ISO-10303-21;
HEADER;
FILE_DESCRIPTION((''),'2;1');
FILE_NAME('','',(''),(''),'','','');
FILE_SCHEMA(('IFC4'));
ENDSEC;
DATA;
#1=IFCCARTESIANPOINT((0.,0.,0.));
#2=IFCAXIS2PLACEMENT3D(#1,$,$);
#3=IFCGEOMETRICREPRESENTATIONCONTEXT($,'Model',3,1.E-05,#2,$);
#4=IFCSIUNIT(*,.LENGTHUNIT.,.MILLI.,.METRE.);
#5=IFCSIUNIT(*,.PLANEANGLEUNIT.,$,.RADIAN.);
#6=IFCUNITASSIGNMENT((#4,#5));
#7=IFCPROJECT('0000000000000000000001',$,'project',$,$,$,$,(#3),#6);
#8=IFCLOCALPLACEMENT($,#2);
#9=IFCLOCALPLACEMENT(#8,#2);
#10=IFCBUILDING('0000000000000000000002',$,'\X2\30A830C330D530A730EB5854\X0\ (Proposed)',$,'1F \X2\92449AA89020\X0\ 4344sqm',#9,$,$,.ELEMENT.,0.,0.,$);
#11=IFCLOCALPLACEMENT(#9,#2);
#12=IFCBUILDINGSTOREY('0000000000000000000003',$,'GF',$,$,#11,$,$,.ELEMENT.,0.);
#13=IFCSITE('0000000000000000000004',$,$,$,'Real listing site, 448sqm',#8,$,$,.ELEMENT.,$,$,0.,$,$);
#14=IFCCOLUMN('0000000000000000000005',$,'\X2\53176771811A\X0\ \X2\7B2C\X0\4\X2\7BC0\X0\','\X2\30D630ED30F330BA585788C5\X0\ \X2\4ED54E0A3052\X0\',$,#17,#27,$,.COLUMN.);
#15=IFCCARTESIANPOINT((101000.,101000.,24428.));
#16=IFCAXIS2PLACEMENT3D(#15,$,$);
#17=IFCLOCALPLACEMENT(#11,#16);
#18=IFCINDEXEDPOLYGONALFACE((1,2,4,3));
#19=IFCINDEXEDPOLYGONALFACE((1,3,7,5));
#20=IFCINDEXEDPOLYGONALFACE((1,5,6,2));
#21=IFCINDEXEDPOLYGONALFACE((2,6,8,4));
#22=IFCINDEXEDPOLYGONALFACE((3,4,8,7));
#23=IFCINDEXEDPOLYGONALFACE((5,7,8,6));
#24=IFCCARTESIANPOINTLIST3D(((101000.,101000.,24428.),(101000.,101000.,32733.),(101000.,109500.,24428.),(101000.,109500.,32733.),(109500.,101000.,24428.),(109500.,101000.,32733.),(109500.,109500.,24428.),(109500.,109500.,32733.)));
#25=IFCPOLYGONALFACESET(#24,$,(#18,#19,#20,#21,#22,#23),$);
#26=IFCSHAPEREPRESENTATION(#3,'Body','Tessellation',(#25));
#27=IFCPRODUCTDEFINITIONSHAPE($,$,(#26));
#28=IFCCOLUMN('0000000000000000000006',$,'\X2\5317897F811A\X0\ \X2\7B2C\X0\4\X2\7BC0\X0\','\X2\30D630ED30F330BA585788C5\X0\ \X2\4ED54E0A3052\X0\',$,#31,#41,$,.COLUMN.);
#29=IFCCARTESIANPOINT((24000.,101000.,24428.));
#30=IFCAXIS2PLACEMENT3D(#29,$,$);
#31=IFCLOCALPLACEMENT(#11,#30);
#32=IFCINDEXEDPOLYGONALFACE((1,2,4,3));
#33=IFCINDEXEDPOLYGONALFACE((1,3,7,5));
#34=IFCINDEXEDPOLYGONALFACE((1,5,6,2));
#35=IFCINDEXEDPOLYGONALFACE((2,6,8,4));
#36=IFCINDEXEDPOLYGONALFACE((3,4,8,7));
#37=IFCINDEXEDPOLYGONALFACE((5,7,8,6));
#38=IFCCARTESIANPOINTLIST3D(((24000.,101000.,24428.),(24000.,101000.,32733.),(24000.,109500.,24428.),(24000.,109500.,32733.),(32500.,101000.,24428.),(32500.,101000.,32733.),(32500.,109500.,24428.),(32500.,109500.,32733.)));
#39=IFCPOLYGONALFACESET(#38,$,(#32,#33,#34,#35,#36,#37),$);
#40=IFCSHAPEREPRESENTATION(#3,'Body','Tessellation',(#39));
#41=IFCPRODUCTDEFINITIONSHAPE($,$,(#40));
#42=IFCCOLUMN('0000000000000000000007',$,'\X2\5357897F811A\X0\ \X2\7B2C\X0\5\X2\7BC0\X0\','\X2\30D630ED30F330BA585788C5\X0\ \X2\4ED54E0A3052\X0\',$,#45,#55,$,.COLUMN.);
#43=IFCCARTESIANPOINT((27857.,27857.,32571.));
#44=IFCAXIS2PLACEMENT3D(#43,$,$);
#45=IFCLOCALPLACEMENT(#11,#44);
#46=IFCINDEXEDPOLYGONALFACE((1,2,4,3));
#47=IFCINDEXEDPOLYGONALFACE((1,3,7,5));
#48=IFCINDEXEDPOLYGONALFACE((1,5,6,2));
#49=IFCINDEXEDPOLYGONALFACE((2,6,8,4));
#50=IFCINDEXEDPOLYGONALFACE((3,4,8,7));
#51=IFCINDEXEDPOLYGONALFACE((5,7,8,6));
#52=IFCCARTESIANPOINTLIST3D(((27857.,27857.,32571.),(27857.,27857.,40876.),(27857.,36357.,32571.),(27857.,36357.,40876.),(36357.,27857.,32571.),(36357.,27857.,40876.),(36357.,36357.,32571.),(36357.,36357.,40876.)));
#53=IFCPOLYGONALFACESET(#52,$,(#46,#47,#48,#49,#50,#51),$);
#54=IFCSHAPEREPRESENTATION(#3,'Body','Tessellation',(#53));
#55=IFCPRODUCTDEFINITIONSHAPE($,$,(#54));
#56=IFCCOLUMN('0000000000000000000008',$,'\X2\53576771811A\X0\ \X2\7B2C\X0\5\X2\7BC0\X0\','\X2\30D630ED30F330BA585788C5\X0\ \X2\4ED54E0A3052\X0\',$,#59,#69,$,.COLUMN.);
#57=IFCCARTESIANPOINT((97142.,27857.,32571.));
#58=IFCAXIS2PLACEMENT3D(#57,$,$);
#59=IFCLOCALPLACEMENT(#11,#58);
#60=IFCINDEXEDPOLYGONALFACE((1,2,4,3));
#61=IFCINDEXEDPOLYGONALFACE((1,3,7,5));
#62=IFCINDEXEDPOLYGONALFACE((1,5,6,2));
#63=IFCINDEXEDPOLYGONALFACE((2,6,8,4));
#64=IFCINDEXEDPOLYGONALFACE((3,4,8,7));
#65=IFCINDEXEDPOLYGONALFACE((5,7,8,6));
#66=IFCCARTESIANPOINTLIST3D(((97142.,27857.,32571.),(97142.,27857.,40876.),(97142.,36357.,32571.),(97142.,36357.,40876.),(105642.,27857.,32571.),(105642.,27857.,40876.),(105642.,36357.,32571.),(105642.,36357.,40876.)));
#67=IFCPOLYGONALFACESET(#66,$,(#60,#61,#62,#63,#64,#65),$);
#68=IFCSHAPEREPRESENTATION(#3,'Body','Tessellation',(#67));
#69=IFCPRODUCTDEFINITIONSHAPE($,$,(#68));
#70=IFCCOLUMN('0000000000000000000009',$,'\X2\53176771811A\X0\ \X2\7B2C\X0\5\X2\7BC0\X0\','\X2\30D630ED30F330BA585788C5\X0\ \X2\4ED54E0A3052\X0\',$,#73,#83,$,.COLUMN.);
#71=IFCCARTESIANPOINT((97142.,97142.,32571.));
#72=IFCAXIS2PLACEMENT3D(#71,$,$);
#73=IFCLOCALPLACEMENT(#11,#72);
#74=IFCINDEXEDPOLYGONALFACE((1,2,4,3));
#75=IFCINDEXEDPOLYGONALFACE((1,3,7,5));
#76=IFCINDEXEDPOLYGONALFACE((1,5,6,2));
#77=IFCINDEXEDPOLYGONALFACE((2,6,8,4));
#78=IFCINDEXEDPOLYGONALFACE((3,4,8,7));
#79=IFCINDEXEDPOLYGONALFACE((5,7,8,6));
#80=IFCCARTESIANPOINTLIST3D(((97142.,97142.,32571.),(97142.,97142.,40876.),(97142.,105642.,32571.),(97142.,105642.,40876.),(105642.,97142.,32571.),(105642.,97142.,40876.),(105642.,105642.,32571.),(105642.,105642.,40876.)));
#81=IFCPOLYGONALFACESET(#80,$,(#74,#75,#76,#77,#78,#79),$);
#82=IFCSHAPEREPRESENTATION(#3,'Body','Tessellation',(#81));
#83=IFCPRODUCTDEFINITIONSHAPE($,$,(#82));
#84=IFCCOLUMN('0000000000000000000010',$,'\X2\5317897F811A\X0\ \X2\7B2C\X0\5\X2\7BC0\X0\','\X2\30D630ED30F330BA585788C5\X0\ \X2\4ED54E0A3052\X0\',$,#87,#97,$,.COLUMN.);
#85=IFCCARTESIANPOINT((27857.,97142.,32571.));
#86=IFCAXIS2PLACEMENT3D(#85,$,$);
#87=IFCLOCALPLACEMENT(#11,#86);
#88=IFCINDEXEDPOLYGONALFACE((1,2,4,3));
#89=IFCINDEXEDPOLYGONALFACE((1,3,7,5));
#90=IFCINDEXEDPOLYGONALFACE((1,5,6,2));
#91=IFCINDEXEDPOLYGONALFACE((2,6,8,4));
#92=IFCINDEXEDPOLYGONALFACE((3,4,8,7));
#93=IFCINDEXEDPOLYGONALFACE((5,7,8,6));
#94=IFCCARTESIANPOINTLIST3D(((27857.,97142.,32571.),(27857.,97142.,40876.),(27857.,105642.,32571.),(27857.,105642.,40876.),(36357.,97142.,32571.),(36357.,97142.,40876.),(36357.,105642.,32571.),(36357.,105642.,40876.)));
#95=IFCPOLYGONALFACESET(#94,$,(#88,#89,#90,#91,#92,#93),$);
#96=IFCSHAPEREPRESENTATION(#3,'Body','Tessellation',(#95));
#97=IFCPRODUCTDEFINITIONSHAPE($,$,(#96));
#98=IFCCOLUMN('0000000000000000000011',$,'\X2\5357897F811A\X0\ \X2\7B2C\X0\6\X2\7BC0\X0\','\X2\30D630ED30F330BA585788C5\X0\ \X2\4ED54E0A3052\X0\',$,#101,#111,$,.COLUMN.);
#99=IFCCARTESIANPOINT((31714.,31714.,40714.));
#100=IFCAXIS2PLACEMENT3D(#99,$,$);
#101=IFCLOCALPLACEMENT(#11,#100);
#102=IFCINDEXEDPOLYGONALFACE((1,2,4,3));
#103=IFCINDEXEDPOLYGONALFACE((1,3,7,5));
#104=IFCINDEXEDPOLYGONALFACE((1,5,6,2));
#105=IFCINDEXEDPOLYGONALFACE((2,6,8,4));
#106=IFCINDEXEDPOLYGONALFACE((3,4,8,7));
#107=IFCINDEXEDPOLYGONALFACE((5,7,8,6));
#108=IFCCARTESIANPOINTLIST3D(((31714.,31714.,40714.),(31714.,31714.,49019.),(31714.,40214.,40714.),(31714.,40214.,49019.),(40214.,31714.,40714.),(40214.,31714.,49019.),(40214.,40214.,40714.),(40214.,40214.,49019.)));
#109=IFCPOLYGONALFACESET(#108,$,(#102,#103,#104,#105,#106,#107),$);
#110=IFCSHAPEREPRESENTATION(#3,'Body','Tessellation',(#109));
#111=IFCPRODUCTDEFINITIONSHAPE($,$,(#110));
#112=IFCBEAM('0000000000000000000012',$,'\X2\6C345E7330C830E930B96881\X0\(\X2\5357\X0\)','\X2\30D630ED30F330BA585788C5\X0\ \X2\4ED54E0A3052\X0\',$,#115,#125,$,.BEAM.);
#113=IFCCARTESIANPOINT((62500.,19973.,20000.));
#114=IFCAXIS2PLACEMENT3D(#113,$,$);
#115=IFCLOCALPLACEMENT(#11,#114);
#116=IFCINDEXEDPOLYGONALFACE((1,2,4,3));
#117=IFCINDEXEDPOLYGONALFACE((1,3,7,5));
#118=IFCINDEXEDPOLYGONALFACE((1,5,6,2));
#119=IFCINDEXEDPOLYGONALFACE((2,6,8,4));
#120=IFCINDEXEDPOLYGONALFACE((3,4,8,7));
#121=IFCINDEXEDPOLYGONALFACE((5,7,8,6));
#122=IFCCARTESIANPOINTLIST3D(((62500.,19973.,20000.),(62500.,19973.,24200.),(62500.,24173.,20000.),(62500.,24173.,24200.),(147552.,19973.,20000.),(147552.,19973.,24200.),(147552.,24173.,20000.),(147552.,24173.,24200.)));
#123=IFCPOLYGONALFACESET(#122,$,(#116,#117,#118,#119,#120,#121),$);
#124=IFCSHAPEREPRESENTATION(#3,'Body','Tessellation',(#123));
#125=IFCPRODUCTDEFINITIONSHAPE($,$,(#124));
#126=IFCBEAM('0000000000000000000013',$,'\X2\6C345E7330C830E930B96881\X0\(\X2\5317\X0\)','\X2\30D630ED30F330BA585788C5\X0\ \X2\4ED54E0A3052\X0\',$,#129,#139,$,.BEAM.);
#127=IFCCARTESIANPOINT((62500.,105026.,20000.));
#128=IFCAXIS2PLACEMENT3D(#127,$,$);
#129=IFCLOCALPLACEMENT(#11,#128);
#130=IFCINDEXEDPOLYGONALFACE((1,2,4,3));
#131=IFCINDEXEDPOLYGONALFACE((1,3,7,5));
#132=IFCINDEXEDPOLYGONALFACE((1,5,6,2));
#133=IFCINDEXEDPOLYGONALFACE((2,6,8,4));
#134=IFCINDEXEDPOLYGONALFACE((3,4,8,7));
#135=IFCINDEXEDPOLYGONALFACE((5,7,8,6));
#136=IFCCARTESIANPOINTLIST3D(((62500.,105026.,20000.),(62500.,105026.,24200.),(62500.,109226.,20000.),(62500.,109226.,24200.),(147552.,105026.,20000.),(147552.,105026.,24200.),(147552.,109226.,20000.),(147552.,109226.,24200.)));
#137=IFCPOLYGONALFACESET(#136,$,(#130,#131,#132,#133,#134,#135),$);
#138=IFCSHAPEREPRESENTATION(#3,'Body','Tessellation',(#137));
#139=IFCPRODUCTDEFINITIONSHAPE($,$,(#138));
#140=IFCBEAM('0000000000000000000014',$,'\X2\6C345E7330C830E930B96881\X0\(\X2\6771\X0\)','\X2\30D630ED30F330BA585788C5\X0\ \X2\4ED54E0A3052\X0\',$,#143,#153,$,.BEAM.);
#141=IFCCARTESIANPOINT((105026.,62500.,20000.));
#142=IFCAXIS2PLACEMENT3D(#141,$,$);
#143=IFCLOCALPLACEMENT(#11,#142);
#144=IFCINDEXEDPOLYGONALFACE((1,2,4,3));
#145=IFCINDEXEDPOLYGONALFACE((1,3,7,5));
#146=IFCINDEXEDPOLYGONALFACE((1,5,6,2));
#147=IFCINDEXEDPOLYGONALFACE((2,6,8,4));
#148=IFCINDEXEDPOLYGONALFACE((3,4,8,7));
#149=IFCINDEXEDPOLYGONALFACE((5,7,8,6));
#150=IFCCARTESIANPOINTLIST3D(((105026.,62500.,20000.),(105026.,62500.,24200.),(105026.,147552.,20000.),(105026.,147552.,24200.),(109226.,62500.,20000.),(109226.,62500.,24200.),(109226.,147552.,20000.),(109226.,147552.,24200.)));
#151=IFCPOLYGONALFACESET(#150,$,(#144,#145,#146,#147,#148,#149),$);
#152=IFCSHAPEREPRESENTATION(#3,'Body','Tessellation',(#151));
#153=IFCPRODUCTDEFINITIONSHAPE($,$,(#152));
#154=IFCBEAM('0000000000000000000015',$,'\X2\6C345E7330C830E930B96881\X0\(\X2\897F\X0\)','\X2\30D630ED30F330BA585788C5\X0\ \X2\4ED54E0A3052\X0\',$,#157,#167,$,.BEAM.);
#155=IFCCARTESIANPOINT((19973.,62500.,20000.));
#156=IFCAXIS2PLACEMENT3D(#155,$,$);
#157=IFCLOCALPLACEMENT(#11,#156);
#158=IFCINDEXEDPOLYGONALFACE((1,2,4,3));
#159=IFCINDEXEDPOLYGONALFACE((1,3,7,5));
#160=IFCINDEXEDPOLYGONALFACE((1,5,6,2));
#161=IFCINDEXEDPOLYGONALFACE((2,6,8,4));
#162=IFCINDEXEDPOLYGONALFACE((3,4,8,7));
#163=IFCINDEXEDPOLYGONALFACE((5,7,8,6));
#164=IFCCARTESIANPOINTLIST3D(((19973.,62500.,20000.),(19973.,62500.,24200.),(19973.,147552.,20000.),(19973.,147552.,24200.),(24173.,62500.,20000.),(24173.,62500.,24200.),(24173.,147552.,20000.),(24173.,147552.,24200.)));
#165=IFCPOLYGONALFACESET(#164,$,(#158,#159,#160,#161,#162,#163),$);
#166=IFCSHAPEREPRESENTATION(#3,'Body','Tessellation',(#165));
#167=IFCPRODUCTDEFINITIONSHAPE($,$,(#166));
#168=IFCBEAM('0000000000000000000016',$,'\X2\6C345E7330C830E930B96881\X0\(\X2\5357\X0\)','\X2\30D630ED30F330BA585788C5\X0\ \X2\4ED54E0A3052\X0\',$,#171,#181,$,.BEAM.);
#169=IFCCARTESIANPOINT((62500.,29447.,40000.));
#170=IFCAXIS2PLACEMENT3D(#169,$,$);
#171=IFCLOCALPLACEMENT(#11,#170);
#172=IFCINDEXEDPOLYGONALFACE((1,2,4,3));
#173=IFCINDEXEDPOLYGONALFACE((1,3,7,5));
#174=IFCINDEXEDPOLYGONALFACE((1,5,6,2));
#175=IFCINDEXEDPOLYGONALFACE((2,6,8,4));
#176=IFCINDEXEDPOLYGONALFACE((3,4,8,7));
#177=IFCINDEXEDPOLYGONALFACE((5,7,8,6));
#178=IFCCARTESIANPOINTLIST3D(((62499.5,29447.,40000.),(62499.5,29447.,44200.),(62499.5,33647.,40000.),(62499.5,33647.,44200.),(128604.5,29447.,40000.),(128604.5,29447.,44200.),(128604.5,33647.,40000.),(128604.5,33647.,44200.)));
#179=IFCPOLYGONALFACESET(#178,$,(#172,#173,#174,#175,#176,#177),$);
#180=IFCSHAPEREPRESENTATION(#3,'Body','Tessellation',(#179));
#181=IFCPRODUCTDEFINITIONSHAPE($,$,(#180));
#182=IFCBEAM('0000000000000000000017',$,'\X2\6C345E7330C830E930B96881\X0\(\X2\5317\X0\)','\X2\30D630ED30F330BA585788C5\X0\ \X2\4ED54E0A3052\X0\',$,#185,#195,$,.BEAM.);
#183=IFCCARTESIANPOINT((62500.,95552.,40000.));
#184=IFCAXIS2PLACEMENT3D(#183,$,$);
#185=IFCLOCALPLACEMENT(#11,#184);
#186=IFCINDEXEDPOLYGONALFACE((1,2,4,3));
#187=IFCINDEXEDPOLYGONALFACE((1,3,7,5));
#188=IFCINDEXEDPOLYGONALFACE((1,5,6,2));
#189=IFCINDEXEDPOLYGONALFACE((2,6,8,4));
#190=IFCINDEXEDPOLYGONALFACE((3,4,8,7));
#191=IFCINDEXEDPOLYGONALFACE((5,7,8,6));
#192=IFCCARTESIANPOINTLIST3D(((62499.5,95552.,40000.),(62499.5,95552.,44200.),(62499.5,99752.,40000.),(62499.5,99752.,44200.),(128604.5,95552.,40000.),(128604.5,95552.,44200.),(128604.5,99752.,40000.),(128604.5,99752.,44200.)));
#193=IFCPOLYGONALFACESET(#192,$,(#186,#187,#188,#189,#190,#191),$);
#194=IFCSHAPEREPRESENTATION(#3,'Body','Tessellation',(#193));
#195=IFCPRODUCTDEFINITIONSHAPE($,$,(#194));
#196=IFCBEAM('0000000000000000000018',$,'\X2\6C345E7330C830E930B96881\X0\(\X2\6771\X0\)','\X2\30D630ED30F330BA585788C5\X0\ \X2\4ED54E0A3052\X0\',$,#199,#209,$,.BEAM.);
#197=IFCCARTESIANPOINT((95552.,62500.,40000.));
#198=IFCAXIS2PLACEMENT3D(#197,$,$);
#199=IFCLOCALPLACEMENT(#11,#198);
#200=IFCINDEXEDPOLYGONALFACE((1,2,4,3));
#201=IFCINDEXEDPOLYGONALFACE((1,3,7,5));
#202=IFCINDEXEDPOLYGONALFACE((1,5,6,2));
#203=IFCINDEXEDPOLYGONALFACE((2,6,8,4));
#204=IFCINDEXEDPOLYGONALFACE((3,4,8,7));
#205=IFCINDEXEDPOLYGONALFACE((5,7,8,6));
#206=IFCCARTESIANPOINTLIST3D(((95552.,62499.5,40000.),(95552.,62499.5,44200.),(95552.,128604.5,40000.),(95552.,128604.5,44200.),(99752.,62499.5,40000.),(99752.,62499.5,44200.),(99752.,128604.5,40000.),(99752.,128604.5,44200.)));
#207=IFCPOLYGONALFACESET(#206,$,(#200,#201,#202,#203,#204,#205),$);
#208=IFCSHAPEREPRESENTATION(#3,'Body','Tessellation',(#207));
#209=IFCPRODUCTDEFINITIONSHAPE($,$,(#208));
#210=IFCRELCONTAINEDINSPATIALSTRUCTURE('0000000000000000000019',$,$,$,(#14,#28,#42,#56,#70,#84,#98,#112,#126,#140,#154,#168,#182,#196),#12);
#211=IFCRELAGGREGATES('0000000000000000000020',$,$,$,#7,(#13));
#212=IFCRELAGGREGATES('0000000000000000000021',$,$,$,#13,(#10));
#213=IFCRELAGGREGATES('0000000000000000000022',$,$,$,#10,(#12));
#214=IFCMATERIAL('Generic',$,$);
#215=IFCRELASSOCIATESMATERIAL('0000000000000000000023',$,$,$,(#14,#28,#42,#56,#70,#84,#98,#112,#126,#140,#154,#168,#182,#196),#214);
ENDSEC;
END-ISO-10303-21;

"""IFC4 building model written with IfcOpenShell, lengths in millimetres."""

from ifc_helpers import new_model, si_unit, frame, frame_2d, origin, place, context, project, spatial, rectangle, extrude, material, element, save


model = new_model("IFC4")

# Units and contexts
model_context = context("Model", 3, precision=1e-05, world=origin())
ifc_project = project(units=[si_unit("LENGTHUNIT", "METRE", prefix="MILLI"), si_unit("PLANEANGLEUNIT", "RADIAN")], contexts=[model_context])

# Site, building, storey
site_placement = place(None, origin())
site = spatial("IfcSite", under=ifc_project, at=site_placement, ObjectType="Real listing site, 448sqm", CompositionType="ELEMENT", RefElevation=0.0)
building_placement = place(site_placement, origin())
building = spatial("IfcBuilding", under=site, at=building_placement, Name="エッフェル塔 (Proposed)", ObjectType="1F 鉄骨造 4344sqm", CompositionType="ELEMENT", ElevationOfRefHeight=0.0, ElevationOfTerrain=0.0)
storey_placement = place(building_placement, origin())
storey = spatial("IfcBuildingStorey", under=building, at=storey_placement, Name="GF", CompositionType="ELEMENT", Elevation=0.0)

# Columns
ifc_material = material(Name="Generic")
column_1_placement = place(storey_placement, frame((101000.0, 101000.0, 24428.0)))
element("IfcColumn", 1, at=column_1_placement, inside=storey, material=ifc_material, Name="北東脚 第4節", Description="ブロンズ塗装 仕上げ", PredefinedType="COLUMN", context=model_context, shape_type="SweptSolid", body=[
    extrude(rectangle(XDim=8500.0, YDim=8500.0, at=frame_2d((4250.0, 4250.0))), frame((101000.0, 101000.0, 24428.0)), (0.0, 0.0, 1.0), 8305.0),
])
column_2_placement = place(storey_placement, frame((24000.0, 101000.0, 24428.0)))
element("IfcColumn", 2, at=column_2_placement, inside=storey, material=ifc_material, Name="北西脚 第4節", Description="ブロンズ塗装 仕上げ", PredefinedType="COLUMN", context=model_context, shape_type="SweptSolid", body=[
    extrude(rectangle(XDim=8500.0, YDim=8500.0, at=frame_2d((4250.0, 4250.0))), frame((24000.0, 101000.0, 24428.0)), (0.0, 0.0, 1.0), 8305.0),
])
column_3_placement = place(storey_placement, frame((27857.0, 27857.0, 32571.0)))
element("IfcColumn", 3, at=column_3_placement, inside=storey, material=ifc_material, Name="南西脚 第5節", Description="ブロンズ塗装 仕上げ", PredefinedType="COLUMN", context=model_context, shape_type="SweptSolid", body=[
    extrude(rectangle(XDim=8500.0, YDim=8500.0, at=frame_2d((4250.0, 4250.0))), frame((27857.0, 27857.0, 32571.0)), (0.0, 0.0, 1.0), 8305.0),
])
column_4_placement = place(storey_placement, frame((97142.0, 27857.0, 32571.0)))
element("IfcColumn", 4, at=column_4_placement, inside=storey, material=ifc_material, Name="南東脚 第5節", Description="ブロンズ塗装 仕上げ", PredefinedType="COLUMN", context=model_context, shape_type="SweptSolid", body=[
    extrude(rectangle(XDim=8500.0, YDim=8500.0, at=frame_2d((4250.0, 4250.0))), frame((97142.0, 27857.0, 32571.0)), (0.0, 0.0, 1.0), 8305.0),
])
column_5_placement = place(storey_placement, frame((97142.0, 97142.0, 32571.0)))
element("IfcColumn", 5, at=column_5_placement, inside=storey, material=ifc_material, Name="北東脚 第5節", Description="ブロンズ塗装 仕上げ", PredefinedType="COLUMN", context=model_context, shape_type="SweptSolid", body=[
    extrude(rectangle(XDim=8500.0, YDim=8500.0, at=frame_2d((4250.0, 4250.0))), frame((97142.0, 97142.0, 32571.0)), (0.0, 0.0, 1.0), 8305.0),
])
column_6_placement = place(storey_placement, frame((27857.0, 97142.0, 32571.0)))
element("IfcColumn", 6, at=column_6_placement, inside=storey, material=ifc_material, Name="北西脚 第5節", Description="ブロンズ塗装 仕上げ", PredefinedType="COLUMN", context=model_context, shape_type="SweptSolid", body=[
    extrude(rectangle(XDim=8500.0, YDim=8500.0, at=frame_2d((4250.0, 4250.0))), frame((27857.0, 97142.0, 32571.0)), (0.0, 0.0, 1.0), 8305.0),
])
column_7_placement = place(storey_placement, frame((31714.0, 31714.0, 40714.0)))
element("IfcColumn", 7, at=column_7_placement, inside=storey, material=ifc_material, Name="南西脚 第6節", Description="ブロンズ塗装 仕上げ", PredefinedType="COLUMN", context=model_context, shape_type="SweptSolid", body=[
    extrude(rectangle(XDim=8500.0, YDim=8500.0, at=frame_2d((4250.0, 4250.0))), frame((31714.0, 31714.0, 40714.0)), (0.0, 0.0, 1.0), 8305.0),
])

# Beams
beam_1_placement = place(storey_placement, frame((62500.0, 19973.0, 20000.0)))
element("IfcBeam", 8, at=beam_1_placement, inside=storey, material=ifc_material, Name="水平トラス梁(南)", Description="ブロンズ塗装 仕上げ", PredefinedType="BEAM", context=model_context, shape_type="SweptSolid", body=[
    extrude(rectangle(XDim=85052.0, YDim=4200.0, at=frame_2d((42526.0, 2100.0))), frame((62500.0, 19973.0, 20000.0)), (0.0, 0.0, 1.0), 4200.0),
])
beam_2_placement = place(storey_placement, frame((62500.0, 105026.0, 20000.0)))
element("IfcBeam", 9, at=beam_2_placement, inside=storey, material=ifc_material, Name="水平トラス梁(北)", Description="ブロンズ塗装 仕上げ", PredefinedType="BEAM", context=model_context, shape_type="SweptSolid", body=[
    extrude(rectangle(XDim=85052.0, YDim=4200.0, at=frame_2d((42526.0, 2100.0))), frame((62500.0, 105026.0, 20000.0)), (0.0, 0.0, 1.0), 4200.0),
])
beam_3_placement = place(storey_placement, frame((105026.0, 62500.0, 20000.0)))
element("IfcBeam", 10, at=beam_3_placement, inside=storey, material=ifc_material, Name="水平トラス梁(東)", Description="ブロンズ塗装 仕上げ", PredefinedType="BEAM", context=model_context, shape_type="SweptSolid", body=[
    extrude(rectangle(XDim=4200.0, YDim=85052.0, at=frame_2d((2100.0, 42526.0))), frame((105026.0, 62500.0, 20000.0)), (0.0, 0.0, 1.0), 4200.0),
])
beam_4_placement = place(storey_placement, frame((19973.0, 62500.0, 20000.0)))
element("IfcBeam", 11, at=beam_4_placement, inside=storey, material=ifc_material, Name="水平トラス梁(西)", Description="ブロンズ塗装 仕上げ", PredefinedType="BEAM", context=model_context, shape_type="SweptSolid", body=[
    extrude(rectangle(XDim=4200.0, YDim=85052.0, at=frame_2d((2100.0, 42526.0))), frame((19973.0, 62500.0, 20000.0)), (0.0, 0.0, 1.0), 4200.0),
])
beam_5_placement = place(storey_placement, frame((62500.0, 29447.0, 40000.0)))
element("IfcBeam", 12, at=beam_5_placement, inside=storey, material=ifc_material, Name="水平トラス梁(南)", Description="ブロンズ塗装 仕上げ", PredefinedType="BEAM", context=model_context, shape_type="SweptSolid", body=[
    extrude(rectangle(XDim=66105.0, YDim=4200.0, at=frame_2d((33052.0, 2100.0))), frame((62500.0, 29447.0, 40000.0)), (0.0, 0.0, 1.0), 4200.0),
])
beam_6_placement = place(storey_placement, frame((62500.0, 95552.0, 40000.0)))
element("IfcBeam", 13, at=beam_6_placement, inside=storey, material=ifc_material, Name="水平トラス梁(北)", Description="ブロンズ塗装 仕上げ", PredefinedType="BEAM", context=model_context, shape_type="SweptSolid", body=[
    extrude(rectangle(XDim=66105.0, YDim=4200.0, at=frame_2d((33052.0, 2100.0))), frame((62500.0, 95552.0, 40000.0)), (0.0, 0.0, 1.0), 4200.0),
])
beam_7_placement = place(storey_placement, frame((95552.0, 62500.0, 40000.0)))
element("IfcBeam", 14, at=beam_7_placement, inside=storey, material=ifc_material, Name="水平トラス梁(東)", Description="ブロンズ塗装 仕上げ", PredefinedType="BEAM", context=model_context, shape_type="SweptSolid", body=[
    extrude(rectangle(XDim=4200.0, YDim=66105.0, at=frame_2d((2100.0, 33052.0))), frame((95552.0, 62500.0, 40000.0)), (0.0, 0.0, 1.0), 4200.0),
])

save(model, "model.ifc")
